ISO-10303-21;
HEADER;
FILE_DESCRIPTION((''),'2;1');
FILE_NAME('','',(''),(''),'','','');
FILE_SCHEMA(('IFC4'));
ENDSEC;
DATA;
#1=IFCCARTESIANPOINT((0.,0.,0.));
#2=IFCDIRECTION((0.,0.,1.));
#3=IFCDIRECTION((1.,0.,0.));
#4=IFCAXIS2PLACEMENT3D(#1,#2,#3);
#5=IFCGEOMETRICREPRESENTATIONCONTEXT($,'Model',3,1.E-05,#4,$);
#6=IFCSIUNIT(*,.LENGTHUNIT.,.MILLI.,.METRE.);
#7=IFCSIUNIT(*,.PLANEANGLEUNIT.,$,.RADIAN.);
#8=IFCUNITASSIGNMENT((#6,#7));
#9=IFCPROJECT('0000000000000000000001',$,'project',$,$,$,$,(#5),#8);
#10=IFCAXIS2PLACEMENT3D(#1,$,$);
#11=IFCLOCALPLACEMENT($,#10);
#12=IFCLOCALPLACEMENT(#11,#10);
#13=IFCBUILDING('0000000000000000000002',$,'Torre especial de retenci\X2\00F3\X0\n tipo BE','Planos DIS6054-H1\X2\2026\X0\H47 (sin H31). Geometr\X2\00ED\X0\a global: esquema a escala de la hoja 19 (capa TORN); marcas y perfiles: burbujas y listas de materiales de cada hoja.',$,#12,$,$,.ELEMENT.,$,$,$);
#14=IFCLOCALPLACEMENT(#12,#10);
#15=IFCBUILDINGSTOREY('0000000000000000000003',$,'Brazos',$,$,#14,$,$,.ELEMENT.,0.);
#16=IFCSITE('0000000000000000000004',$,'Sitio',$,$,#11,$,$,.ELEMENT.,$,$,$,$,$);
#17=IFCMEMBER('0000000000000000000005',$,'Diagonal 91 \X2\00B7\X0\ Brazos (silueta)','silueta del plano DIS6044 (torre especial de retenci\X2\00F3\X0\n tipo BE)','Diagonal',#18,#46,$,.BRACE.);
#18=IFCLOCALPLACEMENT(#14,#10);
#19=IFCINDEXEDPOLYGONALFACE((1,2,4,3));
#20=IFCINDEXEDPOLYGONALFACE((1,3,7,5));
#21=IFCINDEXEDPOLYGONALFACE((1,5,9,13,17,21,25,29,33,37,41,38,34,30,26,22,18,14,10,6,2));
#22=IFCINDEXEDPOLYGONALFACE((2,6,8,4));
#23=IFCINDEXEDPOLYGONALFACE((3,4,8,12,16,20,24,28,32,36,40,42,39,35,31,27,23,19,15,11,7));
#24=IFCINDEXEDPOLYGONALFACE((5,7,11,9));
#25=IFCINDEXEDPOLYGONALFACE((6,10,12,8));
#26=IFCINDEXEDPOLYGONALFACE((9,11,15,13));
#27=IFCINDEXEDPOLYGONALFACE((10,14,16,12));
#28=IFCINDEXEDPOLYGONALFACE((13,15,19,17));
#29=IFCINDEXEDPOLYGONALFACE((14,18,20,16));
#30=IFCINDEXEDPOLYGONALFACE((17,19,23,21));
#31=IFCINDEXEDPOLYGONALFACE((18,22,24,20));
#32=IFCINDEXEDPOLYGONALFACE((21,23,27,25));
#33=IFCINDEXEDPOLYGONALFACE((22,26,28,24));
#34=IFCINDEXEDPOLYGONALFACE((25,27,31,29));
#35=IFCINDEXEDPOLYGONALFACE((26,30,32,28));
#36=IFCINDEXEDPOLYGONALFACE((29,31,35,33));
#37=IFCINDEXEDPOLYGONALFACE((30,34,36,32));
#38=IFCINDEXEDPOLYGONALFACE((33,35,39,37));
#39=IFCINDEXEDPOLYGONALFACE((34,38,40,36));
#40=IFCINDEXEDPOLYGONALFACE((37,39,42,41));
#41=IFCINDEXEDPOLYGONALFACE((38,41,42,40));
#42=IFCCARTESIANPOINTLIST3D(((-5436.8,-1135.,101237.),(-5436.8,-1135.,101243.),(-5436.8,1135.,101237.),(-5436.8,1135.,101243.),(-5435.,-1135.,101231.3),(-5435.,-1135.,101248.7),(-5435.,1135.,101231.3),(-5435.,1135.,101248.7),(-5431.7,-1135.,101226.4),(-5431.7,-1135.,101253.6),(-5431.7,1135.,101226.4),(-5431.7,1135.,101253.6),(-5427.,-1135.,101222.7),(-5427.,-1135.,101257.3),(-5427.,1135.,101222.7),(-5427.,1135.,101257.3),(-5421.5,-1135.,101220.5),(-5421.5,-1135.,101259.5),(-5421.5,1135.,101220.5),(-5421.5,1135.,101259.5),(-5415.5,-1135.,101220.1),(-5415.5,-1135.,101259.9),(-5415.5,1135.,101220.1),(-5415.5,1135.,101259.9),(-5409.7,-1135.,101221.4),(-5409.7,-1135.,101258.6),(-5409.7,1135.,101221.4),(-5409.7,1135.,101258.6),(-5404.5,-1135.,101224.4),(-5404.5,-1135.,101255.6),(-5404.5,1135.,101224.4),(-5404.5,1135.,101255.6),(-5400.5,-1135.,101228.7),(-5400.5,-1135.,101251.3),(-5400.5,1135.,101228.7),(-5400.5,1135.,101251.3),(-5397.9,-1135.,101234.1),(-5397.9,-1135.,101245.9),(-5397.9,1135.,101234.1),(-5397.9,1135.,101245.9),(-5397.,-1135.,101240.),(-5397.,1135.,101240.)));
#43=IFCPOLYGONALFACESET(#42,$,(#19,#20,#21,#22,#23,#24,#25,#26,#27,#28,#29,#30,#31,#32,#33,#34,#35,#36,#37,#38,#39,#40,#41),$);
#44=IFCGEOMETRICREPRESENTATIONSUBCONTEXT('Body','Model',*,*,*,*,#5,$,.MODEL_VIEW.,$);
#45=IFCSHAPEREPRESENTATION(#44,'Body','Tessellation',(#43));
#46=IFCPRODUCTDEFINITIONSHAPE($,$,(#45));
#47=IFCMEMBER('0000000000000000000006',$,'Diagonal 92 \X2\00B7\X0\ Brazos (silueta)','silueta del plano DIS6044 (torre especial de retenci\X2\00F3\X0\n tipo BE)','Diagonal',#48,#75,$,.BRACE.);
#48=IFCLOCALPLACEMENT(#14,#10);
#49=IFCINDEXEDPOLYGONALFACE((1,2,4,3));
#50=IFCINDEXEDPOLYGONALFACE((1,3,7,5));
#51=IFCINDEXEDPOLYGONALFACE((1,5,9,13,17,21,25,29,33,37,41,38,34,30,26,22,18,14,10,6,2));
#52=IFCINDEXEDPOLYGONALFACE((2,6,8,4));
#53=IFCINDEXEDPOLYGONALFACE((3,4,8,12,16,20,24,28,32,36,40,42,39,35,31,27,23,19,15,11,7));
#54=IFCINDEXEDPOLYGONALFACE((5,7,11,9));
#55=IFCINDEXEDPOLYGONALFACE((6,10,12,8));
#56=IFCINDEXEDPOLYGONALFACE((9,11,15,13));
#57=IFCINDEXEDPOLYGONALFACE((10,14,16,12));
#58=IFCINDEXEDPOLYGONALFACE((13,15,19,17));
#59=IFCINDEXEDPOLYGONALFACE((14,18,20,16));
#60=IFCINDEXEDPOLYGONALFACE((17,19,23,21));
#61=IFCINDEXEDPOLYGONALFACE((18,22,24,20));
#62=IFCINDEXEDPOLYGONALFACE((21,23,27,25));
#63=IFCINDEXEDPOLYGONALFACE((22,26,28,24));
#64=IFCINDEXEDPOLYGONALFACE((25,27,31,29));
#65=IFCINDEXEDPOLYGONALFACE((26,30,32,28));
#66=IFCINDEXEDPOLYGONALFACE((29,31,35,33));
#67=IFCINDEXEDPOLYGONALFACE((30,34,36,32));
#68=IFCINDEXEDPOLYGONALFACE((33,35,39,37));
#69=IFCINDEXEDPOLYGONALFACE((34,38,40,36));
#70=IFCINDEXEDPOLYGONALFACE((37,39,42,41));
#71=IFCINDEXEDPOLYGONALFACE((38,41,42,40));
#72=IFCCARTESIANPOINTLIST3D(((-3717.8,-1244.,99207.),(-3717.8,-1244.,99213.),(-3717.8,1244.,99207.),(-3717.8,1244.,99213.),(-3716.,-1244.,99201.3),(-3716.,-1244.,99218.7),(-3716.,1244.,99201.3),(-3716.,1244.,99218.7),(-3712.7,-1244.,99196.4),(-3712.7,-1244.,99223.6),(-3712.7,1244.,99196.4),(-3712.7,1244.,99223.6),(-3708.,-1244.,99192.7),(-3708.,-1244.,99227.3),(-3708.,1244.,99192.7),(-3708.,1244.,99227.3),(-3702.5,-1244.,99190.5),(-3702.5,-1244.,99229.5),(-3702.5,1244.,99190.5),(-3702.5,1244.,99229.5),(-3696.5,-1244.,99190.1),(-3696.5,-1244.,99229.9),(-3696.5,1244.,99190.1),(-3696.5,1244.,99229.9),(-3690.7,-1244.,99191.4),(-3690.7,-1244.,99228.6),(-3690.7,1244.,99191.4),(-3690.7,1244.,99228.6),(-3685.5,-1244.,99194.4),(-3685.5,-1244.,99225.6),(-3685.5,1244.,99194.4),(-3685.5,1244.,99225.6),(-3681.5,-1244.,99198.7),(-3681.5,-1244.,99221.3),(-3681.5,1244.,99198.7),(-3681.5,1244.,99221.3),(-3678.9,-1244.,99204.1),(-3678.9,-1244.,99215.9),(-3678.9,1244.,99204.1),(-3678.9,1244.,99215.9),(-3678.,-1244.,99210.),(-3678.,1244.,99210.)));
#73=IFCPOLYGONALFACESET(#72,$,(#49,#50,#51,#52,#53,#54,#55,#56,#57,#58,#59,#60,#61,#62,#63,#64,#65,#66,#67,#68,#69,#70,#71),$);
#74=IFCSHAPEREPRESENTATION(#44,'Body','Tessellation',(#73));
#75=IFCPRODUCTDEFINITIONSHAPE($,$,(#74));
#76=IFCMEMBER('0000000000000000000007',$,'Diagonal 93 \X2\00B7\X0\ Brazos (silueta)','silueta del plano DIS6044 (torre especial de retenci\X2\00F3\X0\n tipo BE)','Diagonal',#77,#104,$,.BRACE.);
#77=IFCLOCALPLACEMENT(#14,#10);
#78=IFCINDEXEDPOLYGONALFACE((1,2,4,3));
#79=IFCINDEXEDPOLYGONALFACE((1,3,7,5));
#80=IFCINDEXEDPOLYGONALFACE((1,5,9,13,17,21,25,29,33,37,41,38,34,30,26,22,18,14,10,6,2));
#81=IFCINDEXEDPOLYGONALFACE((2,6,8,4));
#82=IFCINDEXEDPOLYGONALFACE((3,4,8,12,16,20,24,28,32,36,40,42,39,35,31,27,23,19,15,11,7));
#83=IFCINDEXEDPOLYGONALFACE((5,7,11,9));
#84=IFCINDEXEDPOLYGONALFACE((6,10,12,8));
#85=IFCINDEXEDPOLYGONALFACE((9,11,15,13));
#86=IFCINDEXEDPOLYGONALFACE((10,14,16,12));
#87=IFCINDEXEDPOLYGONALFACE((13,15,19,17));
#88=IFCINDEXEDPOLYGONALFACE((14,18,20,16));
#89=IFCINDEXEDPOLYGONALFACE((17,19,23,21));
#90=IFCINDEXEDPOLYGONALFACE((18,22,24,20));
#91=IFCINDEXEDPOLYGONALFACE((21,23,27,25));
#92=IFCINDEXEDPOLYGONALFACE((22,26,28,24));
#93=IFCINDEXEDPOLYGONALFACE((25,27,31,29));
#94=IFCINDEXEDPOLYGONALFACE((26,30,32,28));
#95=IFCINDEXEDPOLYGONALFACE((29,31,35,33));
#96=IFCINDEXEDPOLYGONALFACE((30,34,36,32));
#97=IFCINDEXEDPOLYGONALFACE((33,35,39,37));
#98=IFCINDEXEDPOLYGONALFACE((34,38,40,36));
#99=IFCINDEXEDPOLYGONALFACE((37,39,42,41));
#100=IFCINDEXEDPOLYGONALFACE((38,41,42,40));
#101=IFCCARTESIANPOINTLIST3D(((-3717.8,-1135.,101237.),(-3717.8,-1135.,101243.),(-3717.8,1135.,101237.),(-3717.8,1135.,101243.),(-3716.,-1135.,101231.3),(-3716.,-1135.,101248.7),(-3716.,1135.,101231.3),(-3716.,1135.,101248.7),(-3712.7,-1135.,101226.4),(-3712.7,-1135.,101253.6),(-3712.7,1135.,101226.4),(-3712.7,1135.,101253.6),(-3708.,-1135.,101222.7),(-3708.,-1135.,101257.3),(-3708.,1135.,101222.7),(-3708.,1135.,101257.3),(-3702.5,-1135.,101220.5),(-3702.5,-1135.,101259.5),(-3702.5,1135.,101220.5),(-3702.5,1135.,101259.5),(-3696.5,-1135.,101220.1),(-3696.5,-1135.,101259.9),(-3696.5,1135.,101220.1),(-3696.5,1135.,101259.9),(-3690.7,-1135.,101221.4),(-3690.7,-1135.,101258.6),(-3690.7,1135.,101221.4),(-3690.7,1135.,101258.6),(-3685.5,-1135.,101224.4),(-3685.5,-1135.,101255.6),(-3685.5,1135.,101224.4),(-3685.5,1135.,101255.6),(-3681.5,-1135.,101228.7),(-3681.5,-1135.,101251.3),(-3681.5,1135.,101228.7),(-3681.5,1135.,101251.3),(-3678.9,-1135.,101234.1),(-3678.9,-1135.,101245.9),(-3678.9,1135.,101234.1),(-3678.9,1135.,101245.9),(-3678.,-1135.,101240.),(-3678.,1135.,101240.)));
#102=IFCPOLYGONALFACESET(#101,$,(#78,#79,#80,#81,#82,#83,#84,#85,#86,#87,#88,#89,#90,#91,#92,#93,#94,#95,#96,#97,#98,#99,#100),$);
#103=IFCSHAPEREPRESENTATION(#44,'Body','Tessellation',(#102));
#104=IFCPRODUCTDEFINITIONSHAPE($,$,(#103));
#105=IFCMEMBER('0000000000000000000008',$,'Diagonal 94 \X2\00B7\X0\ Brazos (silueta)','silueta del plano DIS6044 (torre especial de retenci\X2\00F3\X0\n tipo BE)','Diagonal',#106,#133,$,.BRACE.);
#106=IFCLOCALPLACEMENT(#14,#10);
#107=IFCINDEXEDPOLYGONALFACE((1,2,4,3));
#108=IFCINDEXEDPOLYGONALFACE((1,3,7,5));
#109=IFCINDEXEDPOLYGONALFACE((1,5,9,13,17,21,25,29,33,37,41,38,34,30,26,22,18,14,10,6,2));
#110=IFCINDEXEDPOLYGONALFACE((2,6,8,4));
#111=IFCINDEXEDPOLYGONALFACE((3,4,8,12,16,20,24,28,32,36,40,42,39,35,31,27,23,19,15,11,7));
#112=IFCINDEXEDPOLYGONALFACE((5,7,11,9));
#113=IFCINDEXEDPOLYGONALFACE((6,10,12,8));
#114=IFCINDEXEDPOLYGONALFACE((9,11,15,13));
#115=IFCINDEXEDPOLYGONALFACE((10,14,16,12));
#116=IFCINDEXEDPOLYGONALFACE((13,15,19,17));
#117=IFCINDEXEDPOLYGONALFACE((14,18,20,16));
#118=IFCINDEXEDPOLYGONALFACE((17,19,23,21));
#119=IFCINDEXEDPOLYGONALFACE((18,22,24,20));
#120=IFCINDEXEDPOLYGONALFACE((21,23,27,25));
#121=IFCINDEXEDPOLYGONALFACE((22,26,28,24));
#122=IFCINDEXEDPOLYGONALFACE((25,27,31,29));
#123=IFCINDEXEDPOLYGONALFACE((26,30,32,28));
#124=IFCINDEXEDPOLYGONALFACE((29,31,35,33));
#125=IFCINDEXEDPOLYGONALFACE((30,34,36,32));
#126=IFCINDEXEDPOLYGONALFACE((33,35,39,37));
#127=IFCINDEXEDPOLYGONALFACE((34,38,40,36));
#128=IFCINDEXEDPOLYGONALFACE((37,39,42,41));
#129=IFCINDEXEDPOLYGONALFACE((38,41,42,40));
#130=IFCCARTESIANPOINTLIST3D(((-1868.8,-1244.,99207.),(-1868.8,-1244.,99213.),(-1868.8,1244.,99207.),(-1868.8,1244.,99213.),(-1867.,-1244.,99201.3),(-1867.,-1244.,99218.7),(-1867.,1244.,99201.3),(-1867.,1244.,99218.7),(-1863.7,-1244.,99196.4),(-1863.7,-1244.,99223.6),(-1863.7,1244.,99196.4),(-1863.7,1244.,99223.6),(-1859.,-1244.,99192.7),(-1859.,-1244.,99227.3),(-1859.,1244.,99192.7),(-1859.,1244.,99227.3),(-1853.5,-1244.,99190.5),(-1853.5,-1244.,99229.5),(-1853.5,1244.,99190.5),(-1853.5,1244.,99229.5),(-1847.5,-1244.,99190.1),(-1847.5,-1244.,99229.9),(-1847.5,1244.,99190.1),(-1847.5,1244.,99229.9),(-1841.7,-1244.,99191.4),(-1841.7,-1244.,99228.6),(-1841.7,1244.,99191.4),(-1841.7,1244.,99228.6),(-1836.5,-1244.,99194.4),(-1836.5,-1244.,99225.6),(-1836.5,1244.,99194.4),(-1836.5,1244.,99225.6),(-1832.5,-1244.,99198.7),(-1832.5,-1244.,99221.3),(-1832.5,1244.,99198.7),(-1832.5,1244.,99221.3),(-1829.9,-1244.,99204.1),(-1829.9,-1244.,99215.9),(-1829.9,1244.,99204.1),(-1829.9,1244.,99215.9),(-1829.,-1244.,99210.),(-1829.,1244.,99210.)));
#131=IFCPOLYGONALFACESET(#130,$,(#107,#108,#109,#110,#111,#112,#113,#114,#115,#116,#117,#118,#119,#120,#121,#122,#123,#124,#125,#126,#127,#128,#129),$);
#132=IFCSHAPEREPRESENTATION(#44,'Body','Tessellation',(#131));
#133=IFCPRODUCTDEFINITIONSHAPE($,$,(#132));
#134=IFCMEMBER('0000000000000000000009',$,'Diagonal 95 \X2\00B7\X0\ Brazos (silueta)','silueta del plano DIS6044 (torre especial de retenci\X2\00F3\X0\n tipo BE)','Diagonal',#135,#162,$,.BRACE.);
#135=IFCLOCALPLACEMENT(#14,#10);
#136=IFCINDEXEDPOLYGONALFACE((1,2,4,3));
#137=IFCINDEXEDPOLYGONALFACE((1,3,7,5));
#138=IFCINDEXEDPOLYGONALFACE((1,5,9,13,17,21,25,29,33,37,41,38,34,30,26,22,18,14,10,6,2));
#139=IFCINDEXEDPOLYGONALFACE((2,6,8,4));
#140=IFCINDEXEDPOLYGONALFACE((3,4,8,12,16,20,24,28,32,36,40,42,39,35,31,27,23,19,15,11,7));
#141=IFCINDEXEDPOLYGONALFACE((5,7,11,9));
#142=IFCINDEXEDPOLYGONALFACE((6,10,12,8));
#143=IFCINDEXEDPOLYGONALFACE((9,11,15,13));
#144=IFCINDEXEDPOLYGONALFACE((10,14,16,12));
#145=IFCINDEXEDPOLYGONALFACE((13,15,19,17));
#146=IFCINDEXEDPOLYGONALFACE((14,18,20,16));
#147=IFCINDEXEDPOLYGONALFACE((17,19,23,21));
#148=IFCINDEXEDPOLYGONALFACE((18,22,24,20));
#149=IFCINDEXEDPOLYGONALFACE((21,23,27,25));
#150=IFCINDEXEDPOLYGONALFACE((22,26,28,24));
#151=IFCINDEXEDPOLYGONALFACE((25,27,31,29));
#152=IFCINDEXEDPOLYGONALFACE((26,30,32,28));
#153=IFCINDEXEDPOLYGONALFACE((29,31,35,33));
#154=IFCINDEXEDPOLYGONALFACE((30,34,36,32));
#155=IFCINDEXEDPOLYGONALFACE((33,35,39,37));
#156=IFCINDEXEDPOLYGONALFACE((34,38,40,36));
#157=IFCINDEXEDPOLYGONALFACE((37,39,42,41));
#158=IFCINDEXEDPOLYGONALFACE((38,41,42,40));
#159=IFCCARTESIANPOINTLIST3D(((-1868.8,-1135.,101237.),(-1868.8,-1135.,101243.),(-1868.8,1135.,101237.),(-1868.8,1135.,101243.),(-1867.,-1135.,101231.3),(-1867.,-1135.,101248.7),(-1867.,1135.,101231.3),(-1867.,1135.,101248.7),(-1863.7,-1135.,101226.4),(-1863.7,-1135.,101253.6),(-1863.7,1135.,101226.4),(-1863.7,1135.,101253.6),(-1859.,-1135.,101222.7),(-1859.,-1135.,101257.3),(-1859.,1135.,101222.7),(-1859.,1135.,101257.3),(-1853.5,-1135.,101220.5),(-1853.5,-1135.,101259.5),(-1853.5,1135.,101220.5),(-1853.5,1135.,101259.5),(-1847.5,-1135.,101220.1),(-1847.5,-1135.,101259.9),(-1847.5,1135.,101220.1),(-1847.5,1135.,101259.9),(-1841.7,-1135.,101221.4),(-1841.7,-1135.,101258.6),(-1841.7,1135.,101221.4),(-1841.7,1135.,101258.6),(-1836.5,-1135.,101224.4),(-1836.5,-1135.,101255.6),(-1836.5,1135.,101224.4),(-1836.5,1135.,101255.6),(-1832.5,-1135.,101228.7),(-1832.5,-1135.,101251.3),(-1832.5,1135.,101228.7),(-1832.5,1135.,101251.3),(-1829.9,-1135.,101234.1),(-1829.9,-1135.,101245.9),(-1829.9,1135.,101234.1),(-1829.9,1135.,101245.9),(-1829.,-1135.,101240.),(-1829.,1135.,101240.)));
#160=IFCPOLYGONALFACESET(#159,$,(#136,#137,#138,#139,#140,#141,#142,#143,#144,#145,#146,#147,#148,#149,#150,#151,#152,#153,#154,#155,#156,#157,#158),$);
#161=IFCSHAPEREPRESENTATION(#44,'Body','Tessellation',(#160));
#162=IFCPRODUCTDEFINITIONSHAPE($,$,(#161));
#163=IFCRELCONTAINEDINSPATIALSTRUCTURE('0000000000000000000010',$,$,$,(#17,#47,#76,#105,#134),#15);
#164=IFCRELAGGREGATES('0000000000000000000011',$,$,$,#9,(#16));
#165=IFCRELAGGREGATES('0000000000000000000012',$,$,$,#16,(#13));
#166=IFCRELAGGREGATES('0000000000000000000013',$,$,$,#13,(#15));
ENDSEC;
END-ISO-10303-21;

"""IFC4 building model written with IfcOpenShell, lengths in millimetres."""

from ifc_helpers import new_model, si_unit, frame, origin, origin_with_axes, place, context, subcontext, project, spatial, circle, extrude, element, save


model = new_model("IFC4")

# Units and contexts
model_context = context("Model", 3, precision=1e-05, world=origin_with_axes())
body_context = subcontext(model_context, "Body", "Model", "MODEL_VIEW")
ifc_project = project(units=[si_unit("LENGTHUNIT", "METRE", prefix="MILLI"), si_unit("PLANEANGLEUNIT", "RADIAN")], contexts=[model_context])

# Site, building, storey
site_placement = place(None, origin())
site = spatial("IfcSite", under=ifc_project, at=site_placement, Name="Sitio", CompositionType="ELEMENT")
building_placement = place(site_placement, origin())
building = spatial("IfcBuilding", under=site, at=building_placement, Name="Torre especial de retención tipo BE", Description="Planos DIS6054-H1…H47 (sin H31). Geometría global: esquema a escala de la hoja 19 (capa TORN); marcas y perfiles: burbujas y listas de materiales de cada hoja.", CompositionType="ELEMENT")
storey_placement = place(building_placement, origin())
storey = spatial("IfcBuildingStorey", under=building, at=storey_placement, Name="Brazos", CompositionType="ELEMENT", Elevation=0.0)

# Members
member_1_placement = place(storey_placement, frame((-5417.0, 1135.0, 101240.0), z_axis=(0.0, -1.0, 0.0), x_axis=(1.0, 0.0, 0.0)))
element("IfcMember", 1, at=member_1_placement, inside=storey, Name="Diagonal 91 · Brazos (silueta)", Description="silueta del plano DIS6044 (torre especial de retención tipo BE)", ObjectType="Diagonal", PredefinedType="BRACE", context=body_context, shape_type="SweptSolid", body=[
    extrude(circle(Radius=20.0), None, (0.0, 0.0, 1.0), 2270.0),
])
member_2_placement = place(storey_placement, frame((-3698.0, 1244.0, 99210.0), z_axis=(0.0, -1.0, 0.0), x_axis=(1.0, 0.0, 0.0)))
element("IfcMember", 2, at=member_2_placement, inside=storey, Name="Diagonal 92 · Brazos (silueta)", Description="silueta del plano DIS6044 (torre especial de retención tipo BE)", ObjectType="Diagonal", PredefinedType="BRACE", context=body_context, shape_type="SweptSolid", body=[
    extrude(circle(Radius=20.0), None, (0.0, 0.0, 1.0), 2488.0),
])
member_3_placement = place(storey_placement, frame((-3698.0, 1135.0, 101240.0), z_axis=(0.0, -1.0, 0.0), x_axis=(1.0, 0.0, 0.0)))
element("IfcMember", 3, at=member_3_placement, inside=storey, Name="Diagonal 93 · Brazos (silueta)", Description="silueta del plano DIS6044 (torre especial de retención tipo BE)", ObjectType="Diagonal", PredefinedType="BRACE", context=body_context, shape_type="SweptSolid", body=[
    extrude(circle(Radius=20.0), None, (0.0, 0.0, 1.0), 2270.0),
])
member_4_placement = place(storey_placement, frame((-1849.0, 1244.0, 99210.0), z_axis=(0.0, -1.0, 0.0), x_axis=(1.0, 0.0, 0.0)))
element("IfcMember", 4, at=member_4_placement, inside=storey, Name="Diagonal 94 · Brazos (silueta)", Description="silueta del plano DIS6044 (torre especial de retención tipo BE)", ObjectType="Diagonal", PredefinedType="BRACE", context=body_context, shape_type="SweptSolid", body=[
    extrude(circle(Radius=20.0), None, (0.0, 0.0, 1.0), 2488.0),
])
member_5_placement = place(storey_placement, frame((-1849.0, 1135.0, 101240.0), z_axis=(0.0, -1.0, 0.0), x_axis=(1.0, 0.0, 0.0)))
element("IfcMember", 5, at=member_5_placement, inside=storey, Name="Diagonal 95 · Brazos (silueta)", Description="silueta del plano DIS6044 (torre especial de retención tipo BE)", ObjectType="Diagonal", PredefinedType="BRACE", context=body_context, shape_type="SweptSolid", body=[
    extrude(circle(Radius=20.0), None, (0.0, 0.0, 1.0), 2270.0),
])

save(model, "model.ifc")
